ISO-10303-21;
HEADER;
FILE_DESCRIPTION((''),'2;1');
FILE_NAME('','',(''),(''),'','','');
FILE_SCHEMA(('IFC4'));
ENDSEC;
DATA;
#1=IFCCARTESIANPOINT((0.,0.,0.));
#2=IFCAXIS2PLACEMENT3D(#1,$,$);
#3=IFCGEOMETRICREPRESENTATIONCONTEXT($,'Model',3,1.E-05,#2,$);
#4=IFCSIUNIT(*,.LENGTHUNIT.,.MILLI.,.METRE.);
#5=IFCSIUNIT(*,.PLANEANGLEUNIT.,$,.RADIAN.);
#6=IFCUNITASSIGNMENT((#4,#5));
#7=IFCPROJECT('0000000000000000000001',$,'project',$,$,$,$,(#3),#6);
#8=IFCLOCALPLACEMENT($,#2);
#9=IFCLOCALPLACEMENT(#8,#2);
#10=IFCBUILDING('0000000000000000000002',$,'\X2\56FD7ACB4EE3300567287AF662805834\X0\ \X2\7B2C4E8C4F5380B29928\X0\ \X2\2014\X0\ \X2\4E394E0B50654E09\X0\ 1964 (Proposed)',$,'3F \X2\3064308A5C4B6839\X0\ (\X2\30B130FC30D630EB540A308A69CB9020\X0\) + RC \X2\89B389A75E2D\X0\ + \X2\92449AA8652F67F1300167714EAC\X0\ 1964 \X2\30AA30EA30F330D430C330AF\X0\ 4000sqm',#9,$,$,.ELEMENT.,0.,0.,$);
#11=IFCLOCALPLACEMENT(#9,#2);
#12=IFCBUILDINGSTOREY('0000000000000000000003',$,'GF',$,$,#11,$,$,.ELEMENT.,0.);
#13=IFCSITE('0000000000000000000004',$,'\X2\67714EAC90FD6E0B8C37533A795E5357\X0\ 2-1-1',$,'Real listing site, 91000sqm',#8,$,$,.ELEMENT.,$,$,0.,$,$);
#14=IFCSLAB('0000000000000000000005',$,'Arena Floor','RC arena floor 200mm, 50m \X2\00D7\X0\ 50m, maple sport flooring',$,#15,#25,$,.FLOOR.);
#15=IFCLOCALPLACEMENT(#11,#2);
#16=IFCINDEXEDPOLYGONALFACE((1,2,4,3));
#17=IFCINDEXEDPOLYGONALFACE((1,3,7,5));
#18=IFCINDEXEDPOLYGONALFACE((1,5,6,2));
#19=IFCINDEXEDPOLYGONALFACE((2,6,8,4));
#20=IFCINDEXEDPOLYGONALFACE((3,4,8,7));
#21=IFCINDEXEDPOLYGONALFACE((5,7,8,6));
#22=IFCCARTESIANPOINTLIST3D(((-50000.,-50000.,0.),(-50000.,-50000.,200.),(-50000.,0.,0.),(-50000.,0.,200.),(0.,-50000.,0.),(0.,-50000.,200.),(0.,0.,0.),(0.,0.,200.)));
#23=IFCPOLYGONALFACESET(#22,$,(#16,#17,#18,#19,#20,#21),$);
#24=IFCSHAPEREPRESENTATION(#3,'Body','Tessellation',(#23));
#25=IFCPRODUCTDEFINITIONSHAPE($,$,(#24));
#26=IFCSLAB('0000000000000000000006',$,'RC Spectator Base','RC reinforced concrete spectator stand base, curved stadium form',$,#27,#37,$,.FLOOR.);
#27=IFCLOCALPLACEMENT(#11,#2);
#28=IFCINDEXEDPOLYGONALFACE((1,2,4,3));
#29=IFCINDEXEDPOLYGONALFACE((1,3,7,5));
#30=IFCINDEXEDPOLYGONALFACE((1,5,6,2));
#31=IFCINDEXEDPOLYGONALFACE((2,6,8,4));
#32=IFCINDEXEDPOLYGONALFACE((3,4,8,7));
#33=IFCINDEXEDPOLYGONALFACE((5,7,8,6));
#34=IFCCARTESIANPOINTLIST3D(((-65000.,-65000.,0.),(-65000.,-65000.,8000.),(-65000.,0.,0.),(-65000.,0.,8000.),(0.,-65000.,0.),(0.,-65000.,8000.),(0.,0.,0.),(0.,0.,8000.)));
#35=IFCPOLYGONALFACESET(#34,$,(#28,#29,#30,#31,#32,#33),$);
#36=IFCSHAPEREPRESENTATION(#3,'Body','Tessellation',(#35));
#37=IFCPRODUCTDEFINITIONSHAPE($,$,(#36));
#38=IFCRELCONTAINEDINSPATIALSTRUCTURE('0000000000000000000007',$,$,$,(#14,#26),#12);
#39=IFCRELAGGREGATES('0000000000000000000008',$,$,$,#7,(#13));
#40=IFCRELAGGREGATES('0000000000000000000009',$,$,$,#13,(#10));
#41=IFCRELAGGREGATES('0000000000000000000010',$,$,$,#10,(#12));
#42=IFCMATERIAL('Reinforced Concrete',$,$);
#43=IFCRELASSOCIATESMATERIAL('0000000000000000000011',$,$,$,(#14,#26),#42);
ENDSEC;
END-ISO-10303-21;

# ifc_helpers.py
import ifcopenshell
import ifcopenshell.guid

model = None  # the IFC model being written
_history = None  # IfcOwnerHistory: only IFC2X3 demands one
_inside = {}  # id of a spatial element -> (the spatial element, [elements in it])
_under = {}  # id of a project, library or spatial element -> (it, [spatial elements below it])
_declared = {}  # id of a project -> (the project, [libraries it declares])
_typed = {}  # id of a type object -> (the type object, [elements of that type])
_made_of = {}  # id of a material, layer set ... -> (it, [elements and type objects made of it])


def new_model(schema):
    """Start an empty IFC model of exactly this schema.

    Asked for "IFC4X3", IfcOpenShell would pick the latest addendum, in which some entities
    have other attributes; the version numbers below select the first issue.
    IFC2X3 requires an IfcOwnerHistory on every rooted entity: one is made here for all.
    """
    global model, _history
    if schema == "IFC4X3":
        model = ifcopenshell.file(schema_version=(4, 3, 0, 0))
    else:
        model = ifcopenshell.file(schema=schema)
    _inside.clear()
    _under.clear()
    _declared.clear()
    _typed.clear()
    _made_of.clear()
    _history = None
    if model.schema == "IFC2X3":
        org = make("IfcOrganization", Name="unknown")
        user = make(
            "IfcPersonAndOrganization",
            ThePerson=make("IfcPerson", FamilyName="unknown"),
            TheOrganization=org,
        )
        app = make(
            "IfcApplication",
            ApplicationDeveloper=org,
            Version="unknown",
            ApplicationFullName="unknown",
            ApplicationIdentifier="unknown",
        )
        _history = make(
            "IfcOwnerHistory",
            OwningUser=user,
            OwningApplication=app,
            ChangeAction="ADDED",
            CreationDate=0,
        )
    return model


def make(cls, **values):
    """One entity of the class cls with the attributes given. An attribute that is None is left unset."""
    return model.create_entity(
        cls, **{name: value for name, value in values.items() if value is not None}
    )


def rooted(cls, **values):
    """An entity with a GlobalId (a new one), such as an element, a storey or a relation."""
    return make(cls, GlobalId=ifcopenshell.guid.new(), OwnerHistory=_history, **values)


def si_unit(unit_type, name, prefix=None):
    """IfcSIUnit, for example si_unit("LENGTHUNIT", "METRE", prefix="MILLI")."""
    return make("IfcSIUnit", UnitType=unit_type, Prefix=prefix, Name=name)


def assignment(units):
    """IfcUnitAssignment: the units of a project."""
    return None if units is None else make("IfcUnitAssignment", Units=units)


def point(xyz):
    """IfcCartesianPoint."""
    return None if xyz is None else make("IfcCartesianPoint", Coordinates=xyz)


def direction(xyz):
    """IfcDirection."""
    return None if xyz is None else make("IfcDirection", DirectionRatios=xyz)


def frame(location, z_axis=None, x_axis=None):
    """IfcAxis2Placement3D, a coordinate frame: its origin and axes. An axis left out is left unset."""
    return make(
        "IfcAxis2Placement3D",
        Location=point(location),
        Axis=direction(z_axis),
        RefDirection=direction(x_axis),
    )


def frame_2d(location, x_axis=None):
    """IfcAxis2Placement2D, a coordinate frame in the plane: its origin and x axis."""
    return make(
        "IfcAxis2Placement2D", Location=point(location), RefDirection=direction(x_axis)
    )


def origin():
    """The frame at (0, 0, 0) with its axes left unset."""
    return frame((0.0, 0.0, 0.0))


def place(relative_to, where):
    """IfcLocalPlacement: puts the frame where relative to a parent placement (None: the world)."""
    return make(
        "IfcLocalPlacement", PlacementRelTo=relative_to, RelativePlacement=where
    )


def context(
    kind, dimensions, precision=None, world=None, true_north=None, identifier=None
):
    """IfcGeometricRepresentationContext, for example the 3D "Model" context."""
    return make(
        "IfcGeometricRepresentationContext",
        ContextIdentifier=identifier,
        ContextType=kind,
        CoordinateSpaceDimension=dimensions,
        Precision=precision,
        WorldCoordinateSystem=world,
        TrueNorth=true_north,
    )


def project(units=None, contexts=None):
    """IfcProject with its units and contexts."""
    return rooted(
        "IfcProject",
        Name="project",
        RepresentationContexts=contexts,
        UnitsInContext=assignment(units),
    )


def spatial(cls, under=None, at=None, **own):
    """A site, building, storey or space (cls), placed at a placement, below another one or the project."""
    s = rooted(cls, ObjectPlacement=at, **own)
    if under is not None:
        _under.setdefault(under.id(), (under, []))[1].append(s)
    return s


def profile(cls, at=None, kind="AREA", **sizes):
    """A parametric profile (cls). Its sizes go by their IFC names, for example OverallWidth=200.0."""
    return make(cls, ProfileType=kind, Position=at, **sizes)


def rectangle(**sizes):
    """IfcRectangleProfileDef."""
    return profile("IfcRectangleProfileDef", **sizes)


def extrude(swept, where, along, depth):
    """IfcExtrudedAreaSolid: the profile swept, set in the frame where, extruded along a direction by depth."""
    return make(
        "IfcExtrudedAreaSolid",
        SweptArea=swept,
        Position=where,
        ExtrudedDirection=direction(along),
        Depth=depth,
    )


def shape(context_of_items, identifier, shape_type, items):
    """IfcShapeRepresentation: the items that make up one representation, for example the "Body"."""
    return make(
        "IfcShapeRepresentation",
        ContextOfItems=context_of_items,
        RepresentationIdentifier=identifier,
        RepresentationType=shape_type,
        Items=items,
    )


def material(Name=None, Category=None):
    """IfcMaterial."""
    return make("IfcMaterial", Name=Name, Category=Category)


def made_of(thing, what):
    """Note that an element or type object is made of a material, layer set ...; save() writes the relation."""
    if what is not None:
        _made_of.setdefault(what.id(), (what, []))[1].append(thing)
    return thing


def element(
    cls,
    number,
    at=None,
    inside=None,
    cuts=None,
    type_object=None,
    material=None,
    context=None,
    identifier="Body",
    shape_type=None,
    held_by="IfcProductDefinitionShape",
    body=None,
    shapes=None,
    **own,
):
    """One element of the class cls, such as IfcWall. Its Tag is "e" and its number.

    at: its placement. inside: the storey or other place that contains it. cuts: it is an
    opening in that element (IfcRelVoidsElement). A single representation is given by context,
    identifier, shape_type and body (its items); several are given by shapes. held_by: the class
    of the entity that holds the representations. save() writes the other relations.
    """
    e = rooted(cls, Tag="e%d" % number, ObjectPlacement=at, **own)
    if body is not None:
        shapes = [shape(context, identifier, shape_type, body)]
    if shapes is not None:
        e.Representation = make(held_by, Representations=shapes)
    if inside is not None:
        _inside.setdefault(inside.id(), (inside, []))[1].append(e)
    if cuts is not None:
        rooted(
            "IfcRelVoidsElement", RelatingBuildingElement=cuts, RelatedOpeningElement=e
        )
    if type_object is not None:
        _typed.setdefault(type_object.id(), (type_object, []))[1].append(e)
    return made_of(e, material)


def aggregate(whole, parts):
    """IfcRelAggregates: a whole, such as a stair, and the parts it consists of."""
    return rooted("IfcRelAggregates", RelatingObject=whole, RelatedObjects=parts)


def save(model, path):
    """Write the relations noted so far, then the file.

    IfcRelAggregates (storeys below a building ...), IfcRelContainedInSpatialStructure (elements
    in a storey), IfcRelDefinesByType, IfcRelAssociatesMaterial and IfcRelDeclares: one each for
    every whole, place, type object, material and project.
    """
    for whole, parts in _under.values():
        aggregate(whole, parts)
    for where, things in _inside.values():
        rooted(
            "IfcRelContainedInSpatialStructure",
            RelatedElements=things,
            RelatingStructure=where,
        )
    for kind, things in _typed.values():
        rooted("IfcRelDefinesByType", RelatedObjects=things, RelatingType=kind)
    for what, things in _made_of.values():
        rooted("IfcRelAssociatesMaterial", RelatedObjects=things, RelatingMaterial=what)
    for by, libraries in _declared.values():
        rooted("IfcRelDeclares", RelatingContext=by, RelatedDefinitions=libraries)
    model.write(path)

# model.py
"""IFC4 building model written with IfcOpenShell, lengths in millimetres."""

from ifc_helpers import new_model, si_unit, frame, frame_2d, origin, place, context, project, spatial, rectangle, extrude, material, element, save


model = new_model("IFC4")

# Units and contexts
model_context = context("Model", 3, precision=1e-05, world=origin())
ifc_project = project(units=[si_unit("LENGTHUNIT", "METRE", prefix="MILLI"), si_unit("PLANEANGLEUNIT", "RADIAN")], contexts=[model_context])

# Site, building, storey
site_placement = place(None, origin())
site = spatial("IfcSite", under=ifc_project, at=site_placement, Name="東京都渋谷区神南 2-1-1", ObjectType="Real listing site, 91000sqm", CompositionType="ELEMENT", RefElevation=0.0)
building_placement = place(site_placement, origin())
building = spatial("IfcBuilding", under=site, at=building_placement, Name="国立代々木競技場 第二体育館 — 丹下健三 1964 (Proposed)", ObjectType="3F つり屋根 (ケーブル吊り構造) + RC 観覧席 + 鉄骨支柱、東京 1964 オリンピック 4000sqm", CompositionType="ELEMENT", ElevationOfRefHeight=0.0, ElevationOfTerrain=0.0)
storey_placement = place(building_placement, origin())
storey = spatial("IfcBuildingStorey", under=building, at=storey_placement, Name="GF", CompositionType="ELEMENT", Elevation=0.0)

# Slabs
ifc_material_1 = material(Name="Reinforced Concrete")
slab_1_placement = place(storey_placement, frame((-25000.0, -25000.0, 0.0)))
element("IfcSlab", 1, at=slab_1_placement, inside=storey, material=ifc_material_1, Name="Arena Floor", Description="RC arena floor 200mm, 50m × 50m, maple sport flooring", PredefinedType="FLOOR", context=model_context, shape_type="SweptSolid", body=[
    extrude(rectangle(XDim=50000.0, YDim=50000.0, at=frame_2d((25000.0, 25000.0))), frame((-25000.0, -25000.0, 0.0)), (0.0, 0.0, 1.0), 200.0),
])
slab_2_placement = place(storey_placement, frame((-32500.0, -32500.0, 0.0)))
element("IfcSlab", 2, at=slab_2_placement, inside=storey, material=ifc_material_1, Name="RC Spectator Base", Description="RC reinforced concrete spectator stand base, curved stadium form", PredefinedType="FLOOR", context=model_context, shape_type="SweptSolid", body=[
    extrude(rectangle(XDim=65000.0, YDim=65000.0, at=frame_2d((32500.0, 32500.0))), frame((-32500.0, -32500.0, 0.0)), (0.0, 0.0, 1.0), 8000.0),
])

save(model, "model.ifc")
